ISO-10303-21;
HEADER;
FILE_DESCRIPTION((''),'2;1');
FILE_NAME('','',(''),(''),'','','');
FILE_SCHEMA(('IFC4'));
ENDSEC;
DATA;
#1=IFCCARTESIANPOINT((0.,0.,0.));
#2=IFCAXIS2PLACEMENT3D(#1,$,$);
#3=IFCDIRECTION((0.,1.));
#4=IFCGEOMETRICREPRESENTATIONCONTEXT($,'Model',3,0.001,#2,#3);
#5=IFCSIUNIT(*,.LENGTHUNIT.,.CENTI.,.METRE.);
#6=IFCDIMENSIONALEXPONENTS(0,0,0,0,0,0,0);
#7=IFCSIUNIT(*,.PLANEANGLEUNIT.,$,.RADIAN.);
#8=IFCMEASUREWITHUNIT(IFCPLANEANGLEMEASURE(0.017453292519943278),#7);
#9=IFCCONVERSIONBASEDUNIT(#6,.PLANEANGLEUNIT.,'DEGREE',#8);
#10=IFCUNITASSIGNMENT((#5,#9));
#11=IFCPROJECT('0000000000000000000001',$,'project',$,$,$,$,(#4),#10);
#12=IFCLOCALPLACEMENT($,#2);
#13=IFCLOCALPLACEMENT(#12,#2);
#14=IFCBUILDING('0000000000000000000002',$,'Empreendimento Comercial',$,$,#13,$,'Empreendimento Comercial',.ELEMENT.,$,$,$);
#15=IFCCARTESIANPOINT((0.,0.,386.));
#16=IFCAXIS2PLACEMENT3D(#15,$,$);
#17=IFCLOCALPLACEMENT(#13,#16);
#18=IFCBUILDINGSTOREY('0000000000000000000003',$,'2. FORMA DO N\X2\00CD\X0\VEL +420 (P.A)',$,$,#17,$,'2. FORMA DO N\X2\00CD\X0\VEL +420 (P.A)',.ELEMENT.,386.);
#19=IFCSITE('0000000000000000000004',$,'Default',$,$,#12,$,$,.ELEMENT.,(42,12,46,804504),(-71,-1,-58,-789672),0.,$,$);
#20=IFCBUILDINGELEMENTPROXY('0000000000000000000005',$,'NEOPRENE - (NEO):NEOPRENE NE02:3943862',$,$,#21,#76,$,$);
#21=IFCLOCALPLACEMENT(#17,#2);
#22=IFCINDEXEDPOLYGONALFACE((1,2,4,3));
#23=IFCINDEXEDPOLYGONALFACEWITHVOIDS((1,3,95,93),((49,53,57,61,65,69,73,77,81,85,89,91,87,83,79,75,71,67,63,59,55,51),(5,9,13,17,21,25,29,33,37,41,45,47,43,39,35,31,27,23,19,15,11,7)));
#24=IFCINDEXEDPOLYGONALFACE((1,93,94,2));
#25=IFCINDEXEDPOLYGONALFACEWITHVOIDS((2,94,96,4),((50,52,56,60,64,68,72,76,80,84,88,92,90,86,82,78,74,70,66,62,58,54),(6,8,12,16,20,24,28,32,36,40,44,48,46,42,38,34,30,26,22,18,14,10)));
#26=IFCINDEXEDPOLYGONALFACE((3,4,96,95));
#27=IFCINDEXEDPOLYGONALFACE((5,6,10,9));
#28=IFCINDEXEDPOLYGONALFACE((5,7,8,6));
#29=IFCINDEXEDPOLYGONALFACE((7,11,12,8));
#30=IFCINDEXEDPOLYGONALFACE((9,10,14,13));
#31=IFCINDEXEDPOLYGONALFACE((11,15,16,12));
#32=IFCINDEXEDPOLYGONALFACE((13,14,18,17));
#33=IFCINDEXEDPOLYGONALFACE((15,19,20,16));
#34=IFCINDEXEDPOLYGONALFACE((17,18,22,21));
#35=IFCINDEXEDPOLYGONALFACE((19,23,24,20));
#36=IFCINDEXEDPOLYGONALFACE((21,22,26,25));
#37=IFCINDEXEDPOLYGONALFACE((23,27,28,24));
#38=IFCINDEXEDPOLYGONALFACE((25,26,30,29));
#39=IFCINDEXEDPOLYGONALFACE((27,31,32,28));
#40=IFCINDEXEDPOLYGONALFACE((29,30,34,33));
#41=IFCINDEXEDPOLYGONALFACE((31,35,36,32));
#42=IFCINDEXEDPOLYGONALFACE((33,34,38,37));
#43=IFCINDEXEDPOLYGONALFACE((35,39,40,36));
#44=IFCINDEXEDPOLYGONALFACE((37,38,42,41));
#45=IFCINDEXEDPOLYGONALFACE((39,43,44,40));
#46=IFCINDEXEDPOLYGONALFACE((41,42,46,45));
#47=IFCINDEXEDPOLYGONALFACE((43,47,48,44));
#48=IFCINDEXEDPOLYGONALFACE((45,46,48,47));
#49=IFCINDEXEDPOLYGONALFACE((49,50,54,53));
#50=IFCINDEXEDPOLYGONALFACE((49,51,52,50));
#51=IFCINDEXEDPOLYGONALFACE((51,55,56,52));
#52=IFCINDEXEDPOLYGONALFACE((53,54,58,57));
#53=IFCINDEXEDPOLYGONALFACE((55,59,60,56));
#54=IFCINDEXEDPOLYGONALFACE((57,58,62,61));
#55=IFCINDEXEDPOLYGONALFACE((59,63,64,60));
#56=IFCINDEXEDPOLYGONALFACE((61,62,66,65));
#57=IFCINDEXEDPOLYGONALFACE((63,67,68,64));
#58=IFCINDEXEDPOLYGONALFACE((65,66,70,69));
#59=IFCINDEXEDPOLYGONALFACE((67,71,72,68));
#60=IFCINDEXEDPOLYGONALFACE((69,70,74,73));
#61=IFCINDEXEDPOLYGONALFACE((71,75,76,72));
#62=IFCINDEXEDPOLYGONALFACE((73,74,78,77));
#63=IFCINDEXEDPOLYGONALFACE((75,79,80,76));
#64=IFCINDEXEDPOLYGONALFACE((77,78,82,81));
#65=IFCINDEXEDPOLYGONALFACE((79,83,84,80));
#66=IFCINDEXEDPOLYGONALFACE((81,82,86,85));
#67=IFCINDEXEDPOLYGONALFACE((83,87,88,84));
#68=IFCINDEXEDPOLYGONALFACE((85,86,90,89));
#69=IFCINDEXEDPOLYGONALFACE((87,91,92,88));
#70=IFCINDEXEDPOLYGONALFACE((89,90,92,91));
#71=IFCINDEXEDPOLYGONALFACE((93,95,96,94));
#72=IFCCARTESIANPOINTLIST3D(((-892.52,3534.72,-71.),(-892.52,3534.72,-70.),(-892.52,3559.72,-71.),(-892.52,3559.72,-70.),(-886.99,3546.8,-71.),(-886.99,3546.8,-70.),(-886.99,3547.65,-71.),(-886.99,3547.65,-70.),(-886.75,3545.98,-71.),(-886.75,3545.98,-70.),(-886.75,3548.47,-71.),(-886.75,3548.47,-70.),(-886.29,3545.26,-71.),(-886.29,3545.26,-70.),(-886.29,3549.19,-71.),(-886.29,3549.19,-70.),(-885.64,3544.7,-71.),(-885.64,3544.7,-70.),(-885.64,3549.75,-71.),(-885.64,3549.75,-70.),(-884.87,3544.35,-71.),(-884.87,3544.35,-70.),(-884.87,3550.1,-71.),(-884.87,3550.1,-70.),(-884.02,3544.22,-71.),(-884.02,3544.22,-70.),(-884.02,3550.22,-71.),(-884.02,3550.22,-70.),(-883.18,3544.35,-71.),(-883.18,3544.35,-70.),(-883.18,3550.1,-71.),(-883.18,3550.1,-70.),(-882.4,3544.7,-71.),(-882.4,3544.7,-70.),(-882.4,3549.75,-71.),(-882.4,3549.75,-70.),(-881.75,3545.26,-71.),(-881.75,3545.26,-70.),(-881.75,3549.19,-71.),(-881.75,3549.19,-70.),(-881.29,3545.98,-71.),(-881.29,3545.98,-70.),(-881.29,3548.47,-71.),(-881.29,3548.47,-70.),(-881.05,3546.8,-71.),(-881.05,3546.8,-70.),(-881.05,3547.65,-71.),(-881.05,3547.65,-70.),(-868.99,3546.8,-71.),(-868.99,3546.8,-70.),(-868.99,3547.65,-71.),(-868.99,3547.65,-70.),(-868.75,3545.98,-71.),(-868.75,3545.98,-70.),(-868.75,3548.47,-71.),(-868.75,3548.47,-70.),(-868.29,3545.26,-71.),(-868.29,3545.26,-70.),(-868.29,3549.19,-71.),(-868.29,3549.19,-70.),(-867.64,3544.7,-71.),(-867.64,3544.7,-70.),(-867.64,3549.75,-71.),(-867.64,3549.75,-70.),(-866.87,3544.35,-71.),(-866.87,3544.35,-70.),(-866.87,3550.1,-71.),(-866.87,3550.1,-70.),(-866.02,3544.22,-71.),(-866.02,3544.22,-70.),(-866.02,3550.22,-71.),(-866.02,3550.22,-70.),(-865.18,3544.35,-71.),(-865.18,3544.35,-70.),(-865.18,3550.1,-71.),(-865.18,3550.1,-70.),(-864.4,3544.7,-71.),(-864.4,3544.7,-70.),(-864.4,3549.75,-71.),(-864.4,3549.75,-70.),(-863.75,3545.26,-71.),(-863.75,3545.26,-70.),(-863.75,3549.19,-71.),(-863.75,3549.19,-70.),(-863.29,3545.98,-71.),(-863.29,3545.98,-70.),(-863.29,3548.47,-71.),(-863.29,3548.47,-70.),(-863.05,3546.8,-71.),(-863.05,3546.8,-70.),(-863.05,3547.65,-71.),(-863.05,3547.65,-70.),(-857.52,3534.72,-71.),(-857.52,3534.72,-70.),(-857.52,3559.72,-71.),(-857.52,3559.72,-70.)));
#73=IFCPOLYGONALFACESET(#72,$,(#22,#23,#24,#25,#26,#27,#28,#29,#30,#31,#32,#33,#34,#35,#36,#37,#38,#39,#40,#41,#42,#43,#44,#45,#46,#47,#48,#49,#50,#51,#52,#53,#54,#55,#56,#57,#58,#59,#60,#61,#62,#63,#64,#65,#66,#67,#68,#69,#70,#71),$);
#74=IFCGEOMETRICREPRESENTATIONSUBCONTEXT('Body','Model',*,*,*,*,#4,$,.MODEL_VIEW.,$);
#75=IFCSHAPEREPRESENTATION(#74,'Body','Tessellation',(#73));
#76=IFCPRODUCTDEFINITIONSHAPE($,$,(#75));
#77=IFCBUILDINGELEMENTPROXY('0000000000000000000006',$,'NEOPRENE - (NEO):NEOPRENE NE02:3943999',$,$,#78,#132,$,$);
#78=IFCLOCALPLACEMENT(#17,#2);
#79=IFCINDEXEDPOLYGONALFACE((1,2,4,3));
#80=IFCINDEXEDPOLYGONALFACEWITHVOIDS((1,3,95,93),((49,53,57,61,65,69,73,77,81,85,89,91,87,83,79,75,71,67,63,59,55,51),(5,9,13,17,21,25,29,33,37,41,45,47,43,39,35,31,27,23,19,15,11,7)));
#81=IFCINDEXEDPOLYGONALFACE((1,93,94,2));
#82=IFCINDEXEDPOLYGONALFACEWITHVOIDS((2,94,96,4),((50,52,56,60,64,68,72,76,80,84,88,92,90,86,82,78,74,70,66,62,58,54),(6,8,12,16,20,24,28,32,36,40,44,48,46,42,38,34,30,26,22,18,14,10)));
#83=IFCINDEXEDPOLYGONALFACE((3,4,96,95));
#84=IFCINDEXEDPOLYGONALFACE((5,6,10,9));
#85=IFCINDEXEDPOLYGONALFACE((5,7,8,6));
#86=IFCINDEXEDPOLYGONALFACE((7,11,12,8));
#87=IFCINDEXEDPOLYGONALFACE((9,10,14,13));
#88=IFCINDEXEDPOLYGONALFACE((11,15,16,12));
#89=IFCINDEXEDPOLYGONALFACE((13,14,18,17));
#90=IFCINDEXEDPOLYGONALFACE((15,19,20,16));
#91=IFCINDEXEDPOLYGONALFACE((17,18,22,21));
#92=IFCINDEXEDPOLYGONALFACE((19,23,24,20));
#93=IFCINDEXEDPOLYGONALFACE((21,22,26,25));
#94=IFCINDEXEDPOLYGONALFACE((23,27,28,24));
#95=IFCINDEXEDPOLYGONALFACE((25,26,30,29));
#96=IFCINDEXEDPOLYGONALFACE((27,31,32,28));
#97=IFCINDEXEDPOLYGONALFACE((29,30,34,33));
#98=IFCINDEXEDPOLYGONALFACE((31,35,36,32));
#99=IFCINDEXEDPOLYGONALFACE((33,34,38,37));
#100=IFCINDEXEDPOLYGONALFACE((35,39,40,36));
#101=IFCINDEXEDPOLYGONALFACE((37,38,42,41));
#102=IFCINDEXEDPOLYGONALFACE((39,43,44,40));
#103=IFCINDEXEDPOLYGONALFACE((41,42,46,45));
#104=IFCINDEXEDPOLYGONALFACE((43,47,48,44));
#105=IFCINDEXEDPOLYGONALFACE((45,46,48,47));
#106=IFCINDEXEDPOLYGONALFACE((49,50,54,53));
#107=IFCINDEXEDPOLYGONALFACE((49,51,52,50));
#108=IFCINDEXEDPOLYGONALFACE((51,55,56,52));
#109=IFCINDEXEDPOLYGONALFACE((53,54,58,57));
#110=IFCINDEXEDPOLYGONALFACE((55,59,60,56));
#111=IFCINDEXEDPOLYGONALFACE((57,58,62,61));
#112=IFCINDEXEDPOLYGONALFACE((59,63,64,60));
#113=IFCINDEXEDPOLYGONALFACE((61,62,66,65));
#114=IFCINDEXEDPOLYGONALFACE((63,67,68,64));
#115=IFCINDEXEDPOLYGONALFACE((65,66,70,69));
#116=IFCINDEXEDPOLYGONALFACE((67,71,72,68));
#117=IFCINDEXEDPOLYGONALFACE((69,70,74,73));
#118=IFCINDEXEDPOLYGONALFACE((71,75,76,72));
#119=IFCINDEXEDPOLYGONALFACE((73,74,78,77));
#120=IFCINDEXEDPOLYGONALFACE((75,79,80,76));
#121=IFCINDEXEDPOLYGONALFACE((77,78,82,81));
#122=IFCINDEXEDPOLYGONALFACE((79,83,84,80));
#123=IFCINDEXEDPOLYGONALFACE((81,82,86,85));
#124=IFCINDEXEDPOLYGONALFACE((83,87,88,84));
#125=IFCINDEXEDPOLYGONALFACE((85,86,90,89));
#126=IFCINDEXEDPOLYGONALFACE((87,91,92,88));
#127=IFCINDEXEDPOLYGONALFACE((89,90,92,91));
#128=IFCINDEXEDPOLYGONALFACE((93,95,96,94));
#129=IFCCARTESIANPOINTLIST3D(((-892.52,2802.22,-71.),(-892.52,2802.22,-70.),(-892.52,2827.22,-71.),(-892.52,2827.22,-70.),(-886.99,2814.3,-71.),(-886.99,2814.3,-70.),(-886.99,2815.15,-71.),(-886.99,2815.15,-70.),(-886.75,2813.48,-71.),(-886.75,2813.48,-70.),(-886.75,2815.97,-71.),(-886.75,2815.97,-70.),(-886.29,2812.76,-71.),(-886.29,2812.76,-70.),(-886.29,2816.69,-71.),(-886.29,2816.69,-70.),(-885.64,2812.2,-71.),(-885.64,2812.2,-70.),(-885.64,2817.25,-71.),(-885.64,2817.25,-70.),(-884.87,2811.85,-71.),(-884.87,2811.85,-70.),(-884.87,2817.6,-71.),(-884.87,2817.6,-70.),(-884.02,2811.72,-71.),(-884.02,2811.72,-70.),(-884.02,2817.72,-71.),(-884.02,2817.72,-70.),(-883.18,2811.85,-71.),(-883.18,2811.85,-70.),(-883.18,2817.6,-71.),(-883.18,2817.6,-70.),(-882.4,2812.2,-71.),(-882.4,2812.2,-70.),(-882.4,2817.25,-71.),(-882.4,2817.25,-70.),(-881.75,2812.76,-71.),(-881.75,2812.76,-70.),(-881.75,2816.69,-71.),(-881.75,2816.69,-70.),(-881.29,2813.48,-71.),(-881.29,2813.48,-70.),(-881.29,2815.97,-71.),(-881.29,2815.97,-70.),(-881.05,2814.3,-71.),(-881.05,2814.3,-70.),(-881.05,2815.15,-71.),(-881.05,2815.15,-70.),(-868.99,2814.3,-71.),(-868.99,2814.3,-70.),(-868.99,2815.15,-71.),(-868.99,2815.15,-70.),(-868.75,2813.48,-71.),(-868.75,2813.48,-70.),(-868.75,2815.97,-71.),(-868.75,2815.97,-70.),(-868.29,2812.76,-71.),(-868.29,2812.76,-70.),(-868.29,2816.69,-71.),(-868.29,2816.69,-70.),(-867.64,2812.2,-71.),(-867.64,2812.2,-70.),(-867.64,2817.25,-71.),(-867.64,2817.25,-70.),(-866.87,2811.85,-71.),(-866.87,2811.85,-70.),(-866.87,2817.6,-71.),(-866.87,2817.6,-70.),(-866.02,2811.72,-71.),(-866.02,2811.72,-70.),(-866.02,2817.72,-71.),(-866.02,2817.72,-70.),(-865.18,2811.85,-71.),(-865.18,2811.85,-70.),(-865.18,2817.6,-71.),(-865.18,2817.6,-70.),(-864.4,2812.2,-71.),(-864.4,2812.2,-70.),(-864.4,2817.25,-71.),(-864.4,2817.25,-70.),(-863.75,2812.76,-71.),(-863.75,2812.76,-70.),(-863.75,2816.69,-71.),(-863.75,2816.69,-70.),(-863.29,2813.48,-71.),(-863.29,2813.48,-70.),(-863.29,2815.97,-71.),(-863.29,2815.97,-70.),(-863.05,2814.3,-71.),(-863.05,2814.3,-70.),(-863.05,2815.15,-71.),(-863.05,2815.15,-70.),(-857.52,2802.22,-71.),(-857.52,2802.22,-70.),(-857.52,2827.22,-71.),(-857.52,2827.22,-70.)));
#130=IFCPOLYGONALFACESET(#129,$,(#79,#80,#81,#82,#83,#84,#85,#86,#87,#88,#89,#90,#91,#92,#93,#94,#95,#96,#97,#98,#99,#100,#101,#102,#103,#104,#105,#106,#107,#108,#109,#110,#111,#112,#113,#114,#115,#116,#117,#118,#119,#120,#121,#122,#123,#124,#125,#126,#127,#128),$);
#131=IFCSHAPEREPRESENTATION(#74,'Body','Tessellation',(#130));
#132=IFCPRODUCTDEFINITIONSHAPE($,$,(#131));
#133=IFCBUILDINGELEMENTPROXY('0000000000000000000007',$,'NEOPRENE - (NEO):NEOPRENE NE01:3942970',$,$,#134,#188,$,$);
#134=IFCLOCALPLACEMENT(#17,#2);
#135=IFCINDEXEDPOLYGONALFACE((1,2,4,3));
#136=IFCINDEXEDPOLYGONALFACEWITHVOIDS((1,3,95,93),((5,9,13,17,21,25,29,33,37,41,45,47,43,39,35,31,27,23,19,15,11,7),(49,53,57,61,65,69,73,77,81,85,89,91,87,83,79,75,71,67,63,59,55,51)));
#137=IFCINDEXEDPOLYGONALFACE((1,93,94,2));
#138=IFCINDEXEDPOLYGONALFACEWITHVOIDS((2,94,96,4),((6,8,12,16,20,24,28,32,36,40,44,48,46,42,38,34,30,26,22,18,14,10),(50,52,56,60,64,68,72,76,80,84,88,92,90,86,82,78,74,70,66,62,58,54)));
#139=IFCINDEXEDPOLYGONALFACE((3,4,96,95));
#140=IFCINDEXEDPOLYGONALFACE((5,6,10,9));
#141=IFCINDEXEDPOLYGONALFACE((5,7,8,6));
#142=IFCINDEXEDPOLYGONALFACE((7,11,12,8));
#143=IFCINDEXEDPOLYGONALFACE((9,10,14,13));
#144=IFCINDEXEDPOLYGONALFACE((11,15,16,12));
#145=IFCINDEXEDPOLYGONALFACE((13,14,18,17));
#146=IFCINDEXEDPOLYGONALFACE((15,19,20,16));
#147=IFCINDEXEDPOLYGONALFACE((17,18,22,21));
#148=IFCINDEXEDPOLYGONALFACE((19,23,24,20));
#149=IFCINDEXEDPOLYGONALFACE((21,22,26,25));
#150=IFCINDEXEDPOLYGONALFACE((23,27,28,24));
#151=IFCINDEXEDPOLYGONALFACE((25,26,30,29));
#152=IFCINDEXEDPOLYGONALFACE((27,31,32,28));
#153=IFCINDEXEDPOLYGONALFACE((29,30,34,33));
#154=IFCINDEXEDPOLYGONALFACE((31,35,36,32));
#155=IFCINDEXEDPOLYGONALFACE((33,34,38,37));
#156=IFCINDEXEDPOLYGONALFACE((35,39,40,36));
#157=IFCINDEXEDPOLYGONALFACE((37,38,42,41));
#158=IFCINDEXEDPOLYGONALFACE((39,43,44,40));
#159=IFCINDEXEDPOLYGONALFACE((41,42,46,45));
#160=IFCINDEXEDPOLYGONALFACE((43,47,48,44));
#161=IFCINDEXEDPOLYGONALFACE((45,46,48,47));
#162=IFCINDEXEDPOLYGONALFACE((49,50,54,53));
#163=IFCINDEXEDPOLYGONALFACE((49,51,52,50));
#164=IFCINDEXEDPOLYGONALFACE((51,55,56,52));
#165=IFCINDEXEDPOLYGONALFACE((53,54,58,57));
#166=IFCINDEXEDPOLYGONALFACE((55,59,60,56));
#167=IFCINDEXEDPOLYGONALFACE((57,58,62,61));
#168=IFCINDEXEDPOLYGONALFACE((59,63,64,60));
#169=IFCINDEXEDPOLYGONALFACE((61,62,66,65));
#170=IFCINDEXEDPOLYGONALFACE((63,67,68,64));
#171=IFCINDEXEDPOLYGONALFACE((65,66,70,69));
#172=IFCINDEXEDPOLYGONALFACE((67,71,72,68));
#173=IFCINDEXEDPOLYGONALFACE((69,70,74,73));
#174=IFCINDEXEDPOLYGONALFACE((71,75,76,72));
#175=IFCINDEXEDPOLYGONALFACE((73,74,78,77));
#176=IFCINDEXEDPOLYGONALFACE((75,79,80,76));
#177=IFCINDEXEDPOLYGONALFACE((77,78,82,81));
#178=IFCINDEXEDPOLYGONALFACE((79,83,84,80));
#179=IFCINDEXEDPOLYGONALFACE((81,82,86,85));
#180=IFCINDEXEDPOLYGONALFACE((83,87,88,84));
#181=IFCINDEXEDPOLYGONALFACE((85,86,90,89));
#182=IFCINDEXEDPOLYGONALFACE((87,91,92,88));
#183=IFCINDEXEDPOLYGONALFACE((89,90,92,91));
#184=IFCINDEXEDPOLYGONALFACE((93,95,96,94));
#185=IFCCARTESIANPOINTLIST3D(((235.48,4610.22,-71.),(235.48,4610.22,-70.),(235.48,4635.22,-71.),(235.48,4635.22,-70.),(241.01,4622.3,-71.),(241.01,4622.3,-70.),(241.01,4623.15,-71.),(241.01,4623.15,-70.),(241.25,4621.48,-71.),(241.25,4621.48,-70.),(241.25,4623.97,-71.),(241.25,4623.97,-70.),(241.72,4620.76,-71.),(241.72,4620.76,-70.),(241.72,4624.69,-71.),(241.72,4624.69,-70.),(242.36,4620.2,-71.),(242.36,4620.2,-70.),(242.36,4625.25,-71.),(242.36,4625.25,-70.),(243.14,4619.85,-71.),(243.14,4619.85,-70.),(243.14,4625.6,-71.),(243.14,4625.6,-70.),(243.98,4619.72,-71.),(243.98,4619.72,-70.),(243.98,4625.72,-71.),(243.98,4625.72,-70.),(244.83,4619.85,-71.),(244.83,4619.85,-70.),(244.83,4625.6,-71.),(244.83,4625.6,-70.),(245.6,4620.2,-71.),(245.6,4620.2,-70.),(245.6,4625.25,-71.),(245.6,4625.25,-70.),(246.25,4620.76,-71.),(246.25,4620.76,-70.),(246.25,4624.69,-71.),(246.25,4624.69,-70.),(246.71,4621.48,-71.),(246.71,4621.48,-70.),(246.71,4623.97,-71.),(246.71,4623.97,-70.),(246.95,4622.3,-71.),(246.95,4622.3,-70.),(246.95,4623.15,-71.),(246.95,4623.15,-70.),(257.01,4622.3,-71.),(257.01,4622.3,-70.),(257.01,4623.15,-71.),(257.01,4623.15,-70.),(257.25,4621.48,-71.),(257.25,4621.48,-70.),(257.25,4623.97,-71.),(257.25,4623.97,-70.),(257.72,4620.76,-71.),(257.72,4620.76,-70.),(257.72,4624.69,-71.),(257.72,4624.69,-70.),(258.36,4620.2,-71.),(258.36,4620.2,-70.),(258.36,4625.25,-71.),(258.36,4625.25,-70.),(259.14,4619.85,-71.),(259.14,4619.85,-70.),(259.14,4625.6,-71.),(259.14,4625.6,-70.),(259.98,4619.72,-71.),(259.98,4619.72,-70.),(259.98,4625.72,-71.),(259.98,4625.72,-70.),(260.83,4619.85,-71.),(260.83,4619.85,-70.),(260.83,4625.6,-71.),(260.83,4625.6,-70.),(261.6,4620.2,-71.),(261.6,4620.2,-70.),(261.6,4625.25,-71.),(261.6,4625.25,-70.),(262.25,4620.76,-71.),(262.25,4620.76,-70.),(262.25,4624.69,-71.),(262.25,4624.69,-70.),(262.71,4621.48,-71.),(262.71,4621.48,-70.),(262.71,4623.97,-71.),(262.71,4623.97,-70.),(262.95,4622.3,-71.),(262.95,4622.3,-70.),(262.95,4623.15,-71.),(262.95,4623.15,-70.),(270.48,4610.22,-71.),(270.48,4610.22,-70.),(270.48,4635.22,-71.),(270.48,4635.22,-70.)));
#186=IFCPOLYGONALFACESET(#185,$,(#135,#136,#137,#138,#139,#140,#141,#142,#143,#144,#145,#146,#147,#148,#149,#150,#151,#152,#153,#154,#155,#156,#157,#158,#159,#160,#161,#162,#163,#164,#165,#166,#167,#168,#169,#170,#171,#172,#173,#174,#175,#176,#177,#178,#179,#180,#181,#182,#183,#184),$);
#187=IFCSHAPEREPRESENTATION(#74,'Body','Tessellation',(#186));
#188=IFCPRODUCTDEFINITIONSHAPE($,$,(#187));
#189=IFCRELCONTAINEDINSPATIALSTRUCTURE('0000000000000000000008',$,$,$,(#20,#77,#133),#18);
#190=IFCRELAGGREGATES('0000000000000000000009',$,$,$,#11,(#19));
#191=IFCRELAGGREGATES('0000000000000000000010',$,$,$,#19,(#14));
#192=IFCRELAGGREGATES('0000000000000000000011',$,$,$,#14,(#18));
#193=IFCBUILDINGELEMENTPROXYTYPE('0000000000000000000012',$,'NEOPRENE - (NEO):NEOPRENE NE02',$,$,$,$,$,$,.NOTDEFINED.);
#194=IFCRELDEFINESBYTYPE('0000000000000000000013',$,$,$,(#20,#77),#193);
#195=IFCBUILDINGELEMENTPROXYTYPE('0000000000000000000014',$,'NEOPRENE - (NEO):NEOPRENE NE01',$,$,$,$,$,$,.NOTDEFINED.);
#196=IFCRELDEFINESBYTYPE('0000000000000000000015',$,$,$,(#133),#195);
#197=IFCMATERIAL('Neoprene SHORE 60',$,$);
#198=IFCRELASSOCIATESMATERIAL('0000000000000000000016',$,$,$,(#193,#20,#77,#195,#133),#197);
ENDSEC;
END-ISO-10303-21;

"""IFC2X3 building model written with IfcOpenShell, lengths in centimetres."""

from ifc_helpers import new_model, entity, si_unit, converted_unit, direction, frame, frame_2d, origin, place, context, subcontext, project, spatial, polyline, circle_curve, parameter, trimmed, segment, composite_curve, outline, extrude, source, transform, mapped, material, type_object, type_shapes, element, save


model = new_model("IFC2X3")

# Units and contexts
model_context = context("Model", 3, precision=0.001, world=origin(), true_north=direction((0.0, 1.0)))
body_context = subcontext(model_context, "Body", "Model", "MODEL_VIEW")
ifc_project = project(units=[si_unit("LENGTHUNIT", "METRE", prefix="CENTI"), converted_unit("PLANEANGLEUNIT", "DEGREE", entity("IfcPlaneAngleMeasure", 0.017453292519943278), si_unit("PLANEANGLEUNIT", "RADIAN"), dimensions=[0, 0, 0, 0, 0, 0, 0])], contexts=[model_context])

# Site, building, storey
site_placement = place(None, origin())
site = spatial("IfcSite", under=ifc_project, at=site_placement, Name="Default", CompositionType="ELEMENT", RefLatitude=(42, 12, 46, 804504), RefLongitude=(-71, -1, -58, -789672), RefElevation=0.0)
building_placement = place(site_placement, origin())
building = spatial("IfcBuilding", under=site, at=building_placement, Name="Empreendimento Comercial", LongName="Empreendimento Comercial", CompositionType="ELEMENT")
storey_placement = place(building_placement, frame((0.0, 0.0, 386.0)))
storey = spatial("IfcBuildingStorey", under=building, at=storey_placement, Name="2. FORMA DO NÍVEL +420 (P.A)", LongName="2. FORMA DO NÍVEL +420 (P.A)", CompositionType="ELEMENT", Elevation=386.0)

# Building element proxies
ifc_material = material(Name="Neoprene SHORE 60")
building_element_proxy_type_1 = type_object("IfcBuildingElementProxyType", Name="NEOPRENE - (NEO):NEOPRENE NE02", PredefinedType="NOTDEFINED", material=ifc_material)
shared_shape_1 = source(origin(), body_context, "Body", "SweptSolid", [
    extrude(outline(polyline([(-17.5, -12.5), (17.5, -12.5), (17.5, 12.5), (-17.5, 12.5), (-17.5, -12.5)]), holes=[composite_curve([segment(trimmed(circle_curve(frame_2d((-9.0, 0.0), x_axis=(0.0, -1.0)), 3.0), [parameter(0.0)], [parameter(180.0)], True, "PARAMETER"), False, "CONTINUOUS"), segment(trimmed(circle_curve(frame_2d((-9.0, 0.0), x_axis=(0.0, -1.0)), 3.0), [parameter(180.0)], [parameter(0.0)], True, "PARAMETER"), False, "CONTINUOUS")], self_intersect=False), composite_curve([segment(trimmed(circle_curve(frame_2d((9.0, 0.0), x_axis=(0.0, -1.0)), 3.0), [parameter(0.0)], [parameter(180.0)], True, "PARAMETER"), False, "CONTINUOUS"), segment(trimmed(circle_curve(frame_2d((9.0, 0.0), x_axis=(0.0, -1.0)), 3.0), [parameter(180.0)], [parameter(0.0)], True, "PARAMETER"), False, "CONTINUOUS")], self_intersect=False)]), frame((0.0, 0.0, -71.0), z_axis=(0.0, 0.0, 1.0), x_axis=(0.0, 1.0, 0.0)), (0.0, 0.0, 1.0), 1.0),
])
type_shapes(building_element_proxy_type_1, [shared_shape_1])
for number, where, z_axis, x_axis, name in (
    (1, (-875.02, 3547.22, 0.0), (0.0, 0.0, 1.0), (0.0, 1.0, 0.0), "NEOPRENE - (NEO):NEOPRENE NE02:3943862"),
    (2, (-875.02, 2814.72, 0.0), (0.0, 0.0, 1.0), (0.0, 1.0, 0.0), "NEOPRENE - (NEO):NEOPRENE NE02:3943999"),
):
    element("IfcBuildingElementProxy", number, at=place(storey_placement, frame(where, z_axis=z_axis, x_axis=x_axis)), inside=storey, type_object=building_element_proxy_type_1, material=ifc_material, Name=name, context=body_context, shape_type="MappedRepresentation", body=[
        mapped(shared_shape_1, transform((0.0, 0.0, 0.0), scale=1.0)),
    ])
building_element_proxy_type_2 = type_object("IfcBuildingElementProxyType", Name="NEOPRENE - (NEO):NEOPRENE NE01", PredefinedType="NOTDEFINED", material=ifc_material)
shared_shape_2 = source(origin(), body_context, "Body", "SweptSolid", [
    extrude(outline(polyline([(-17.5, -12.5), (17.5, -12.5), (17.5, 12.5), (-17.5, 12.5), (-17.5, -12.5)]), holes=[composite_curve([segment(trimmed(circle_curve(frame_2d((-7.0, 0.0), x_axis=(0.0, -1.0)), 3.0), [parameter(0.0)], [parameter(180.0)], True, "PARAMETER"), False, "CONTINUOUS"), segment(trimmed(circle_curve(frame_2d((-7.0, 0.0), x_axis=(0.0, -1.0)), 3.0), [parameter(180.0)], [parameter(0.0)], True, "PARAMETER"), False, "CONTINUOUS")], self_intersect=False), composite_curve([segment(trimmed(circle_curve(frame_2d((9.0, 0.0), x_axis=(0.0, -1.0)), 3.0), [parameter(0.0)], [parameter(180.0)], True, "PARAMETER"), False, "CONTINUOUS"), segment(trimmed(circle_curve(frame_2d((9.0, 0.0), x_axis=(0.0, -1.0)), 3.0), [parameter(180.0)], [parameter(0.0)], True, "PARAMETER"), False, "CONTINUOUS")], self_intersect=False)]), frame((0.0, 0.0, -71.0), z_axis=(0.0, 0.0, 1.0), x_axis=(0.0, 1.0, 0.0)), (0.0, 0.0, 1.0), 1.0),
])
type_shapes(building_element_proxy_type_2, [shared_shape_2])
for number, where, z_axis, x_axis, name in (
    (3, (252.98, 4622.72, 0.0), (0.0, 0.0, 1.0), (0.0, 1.0, 0.0), "NEOPRENE - (NEO):NEOPRENE NE01:3942970"),
):
    element("IfcBuildingElementProxy", number, at=place(storey_placement, frame(where, z_axis=z_axis, x_axis=x_axis)), inside=storey, type_object=building_element_proxy_type_2, material=ifc_material, Name=name, context=body_context, shape_type="MappedRepresentation", body=[
        mapped(shared_shape_2, transform((0.0, 0.0, 0.0), scale=1.0)),
    ])

save(model, "model.ifc")
